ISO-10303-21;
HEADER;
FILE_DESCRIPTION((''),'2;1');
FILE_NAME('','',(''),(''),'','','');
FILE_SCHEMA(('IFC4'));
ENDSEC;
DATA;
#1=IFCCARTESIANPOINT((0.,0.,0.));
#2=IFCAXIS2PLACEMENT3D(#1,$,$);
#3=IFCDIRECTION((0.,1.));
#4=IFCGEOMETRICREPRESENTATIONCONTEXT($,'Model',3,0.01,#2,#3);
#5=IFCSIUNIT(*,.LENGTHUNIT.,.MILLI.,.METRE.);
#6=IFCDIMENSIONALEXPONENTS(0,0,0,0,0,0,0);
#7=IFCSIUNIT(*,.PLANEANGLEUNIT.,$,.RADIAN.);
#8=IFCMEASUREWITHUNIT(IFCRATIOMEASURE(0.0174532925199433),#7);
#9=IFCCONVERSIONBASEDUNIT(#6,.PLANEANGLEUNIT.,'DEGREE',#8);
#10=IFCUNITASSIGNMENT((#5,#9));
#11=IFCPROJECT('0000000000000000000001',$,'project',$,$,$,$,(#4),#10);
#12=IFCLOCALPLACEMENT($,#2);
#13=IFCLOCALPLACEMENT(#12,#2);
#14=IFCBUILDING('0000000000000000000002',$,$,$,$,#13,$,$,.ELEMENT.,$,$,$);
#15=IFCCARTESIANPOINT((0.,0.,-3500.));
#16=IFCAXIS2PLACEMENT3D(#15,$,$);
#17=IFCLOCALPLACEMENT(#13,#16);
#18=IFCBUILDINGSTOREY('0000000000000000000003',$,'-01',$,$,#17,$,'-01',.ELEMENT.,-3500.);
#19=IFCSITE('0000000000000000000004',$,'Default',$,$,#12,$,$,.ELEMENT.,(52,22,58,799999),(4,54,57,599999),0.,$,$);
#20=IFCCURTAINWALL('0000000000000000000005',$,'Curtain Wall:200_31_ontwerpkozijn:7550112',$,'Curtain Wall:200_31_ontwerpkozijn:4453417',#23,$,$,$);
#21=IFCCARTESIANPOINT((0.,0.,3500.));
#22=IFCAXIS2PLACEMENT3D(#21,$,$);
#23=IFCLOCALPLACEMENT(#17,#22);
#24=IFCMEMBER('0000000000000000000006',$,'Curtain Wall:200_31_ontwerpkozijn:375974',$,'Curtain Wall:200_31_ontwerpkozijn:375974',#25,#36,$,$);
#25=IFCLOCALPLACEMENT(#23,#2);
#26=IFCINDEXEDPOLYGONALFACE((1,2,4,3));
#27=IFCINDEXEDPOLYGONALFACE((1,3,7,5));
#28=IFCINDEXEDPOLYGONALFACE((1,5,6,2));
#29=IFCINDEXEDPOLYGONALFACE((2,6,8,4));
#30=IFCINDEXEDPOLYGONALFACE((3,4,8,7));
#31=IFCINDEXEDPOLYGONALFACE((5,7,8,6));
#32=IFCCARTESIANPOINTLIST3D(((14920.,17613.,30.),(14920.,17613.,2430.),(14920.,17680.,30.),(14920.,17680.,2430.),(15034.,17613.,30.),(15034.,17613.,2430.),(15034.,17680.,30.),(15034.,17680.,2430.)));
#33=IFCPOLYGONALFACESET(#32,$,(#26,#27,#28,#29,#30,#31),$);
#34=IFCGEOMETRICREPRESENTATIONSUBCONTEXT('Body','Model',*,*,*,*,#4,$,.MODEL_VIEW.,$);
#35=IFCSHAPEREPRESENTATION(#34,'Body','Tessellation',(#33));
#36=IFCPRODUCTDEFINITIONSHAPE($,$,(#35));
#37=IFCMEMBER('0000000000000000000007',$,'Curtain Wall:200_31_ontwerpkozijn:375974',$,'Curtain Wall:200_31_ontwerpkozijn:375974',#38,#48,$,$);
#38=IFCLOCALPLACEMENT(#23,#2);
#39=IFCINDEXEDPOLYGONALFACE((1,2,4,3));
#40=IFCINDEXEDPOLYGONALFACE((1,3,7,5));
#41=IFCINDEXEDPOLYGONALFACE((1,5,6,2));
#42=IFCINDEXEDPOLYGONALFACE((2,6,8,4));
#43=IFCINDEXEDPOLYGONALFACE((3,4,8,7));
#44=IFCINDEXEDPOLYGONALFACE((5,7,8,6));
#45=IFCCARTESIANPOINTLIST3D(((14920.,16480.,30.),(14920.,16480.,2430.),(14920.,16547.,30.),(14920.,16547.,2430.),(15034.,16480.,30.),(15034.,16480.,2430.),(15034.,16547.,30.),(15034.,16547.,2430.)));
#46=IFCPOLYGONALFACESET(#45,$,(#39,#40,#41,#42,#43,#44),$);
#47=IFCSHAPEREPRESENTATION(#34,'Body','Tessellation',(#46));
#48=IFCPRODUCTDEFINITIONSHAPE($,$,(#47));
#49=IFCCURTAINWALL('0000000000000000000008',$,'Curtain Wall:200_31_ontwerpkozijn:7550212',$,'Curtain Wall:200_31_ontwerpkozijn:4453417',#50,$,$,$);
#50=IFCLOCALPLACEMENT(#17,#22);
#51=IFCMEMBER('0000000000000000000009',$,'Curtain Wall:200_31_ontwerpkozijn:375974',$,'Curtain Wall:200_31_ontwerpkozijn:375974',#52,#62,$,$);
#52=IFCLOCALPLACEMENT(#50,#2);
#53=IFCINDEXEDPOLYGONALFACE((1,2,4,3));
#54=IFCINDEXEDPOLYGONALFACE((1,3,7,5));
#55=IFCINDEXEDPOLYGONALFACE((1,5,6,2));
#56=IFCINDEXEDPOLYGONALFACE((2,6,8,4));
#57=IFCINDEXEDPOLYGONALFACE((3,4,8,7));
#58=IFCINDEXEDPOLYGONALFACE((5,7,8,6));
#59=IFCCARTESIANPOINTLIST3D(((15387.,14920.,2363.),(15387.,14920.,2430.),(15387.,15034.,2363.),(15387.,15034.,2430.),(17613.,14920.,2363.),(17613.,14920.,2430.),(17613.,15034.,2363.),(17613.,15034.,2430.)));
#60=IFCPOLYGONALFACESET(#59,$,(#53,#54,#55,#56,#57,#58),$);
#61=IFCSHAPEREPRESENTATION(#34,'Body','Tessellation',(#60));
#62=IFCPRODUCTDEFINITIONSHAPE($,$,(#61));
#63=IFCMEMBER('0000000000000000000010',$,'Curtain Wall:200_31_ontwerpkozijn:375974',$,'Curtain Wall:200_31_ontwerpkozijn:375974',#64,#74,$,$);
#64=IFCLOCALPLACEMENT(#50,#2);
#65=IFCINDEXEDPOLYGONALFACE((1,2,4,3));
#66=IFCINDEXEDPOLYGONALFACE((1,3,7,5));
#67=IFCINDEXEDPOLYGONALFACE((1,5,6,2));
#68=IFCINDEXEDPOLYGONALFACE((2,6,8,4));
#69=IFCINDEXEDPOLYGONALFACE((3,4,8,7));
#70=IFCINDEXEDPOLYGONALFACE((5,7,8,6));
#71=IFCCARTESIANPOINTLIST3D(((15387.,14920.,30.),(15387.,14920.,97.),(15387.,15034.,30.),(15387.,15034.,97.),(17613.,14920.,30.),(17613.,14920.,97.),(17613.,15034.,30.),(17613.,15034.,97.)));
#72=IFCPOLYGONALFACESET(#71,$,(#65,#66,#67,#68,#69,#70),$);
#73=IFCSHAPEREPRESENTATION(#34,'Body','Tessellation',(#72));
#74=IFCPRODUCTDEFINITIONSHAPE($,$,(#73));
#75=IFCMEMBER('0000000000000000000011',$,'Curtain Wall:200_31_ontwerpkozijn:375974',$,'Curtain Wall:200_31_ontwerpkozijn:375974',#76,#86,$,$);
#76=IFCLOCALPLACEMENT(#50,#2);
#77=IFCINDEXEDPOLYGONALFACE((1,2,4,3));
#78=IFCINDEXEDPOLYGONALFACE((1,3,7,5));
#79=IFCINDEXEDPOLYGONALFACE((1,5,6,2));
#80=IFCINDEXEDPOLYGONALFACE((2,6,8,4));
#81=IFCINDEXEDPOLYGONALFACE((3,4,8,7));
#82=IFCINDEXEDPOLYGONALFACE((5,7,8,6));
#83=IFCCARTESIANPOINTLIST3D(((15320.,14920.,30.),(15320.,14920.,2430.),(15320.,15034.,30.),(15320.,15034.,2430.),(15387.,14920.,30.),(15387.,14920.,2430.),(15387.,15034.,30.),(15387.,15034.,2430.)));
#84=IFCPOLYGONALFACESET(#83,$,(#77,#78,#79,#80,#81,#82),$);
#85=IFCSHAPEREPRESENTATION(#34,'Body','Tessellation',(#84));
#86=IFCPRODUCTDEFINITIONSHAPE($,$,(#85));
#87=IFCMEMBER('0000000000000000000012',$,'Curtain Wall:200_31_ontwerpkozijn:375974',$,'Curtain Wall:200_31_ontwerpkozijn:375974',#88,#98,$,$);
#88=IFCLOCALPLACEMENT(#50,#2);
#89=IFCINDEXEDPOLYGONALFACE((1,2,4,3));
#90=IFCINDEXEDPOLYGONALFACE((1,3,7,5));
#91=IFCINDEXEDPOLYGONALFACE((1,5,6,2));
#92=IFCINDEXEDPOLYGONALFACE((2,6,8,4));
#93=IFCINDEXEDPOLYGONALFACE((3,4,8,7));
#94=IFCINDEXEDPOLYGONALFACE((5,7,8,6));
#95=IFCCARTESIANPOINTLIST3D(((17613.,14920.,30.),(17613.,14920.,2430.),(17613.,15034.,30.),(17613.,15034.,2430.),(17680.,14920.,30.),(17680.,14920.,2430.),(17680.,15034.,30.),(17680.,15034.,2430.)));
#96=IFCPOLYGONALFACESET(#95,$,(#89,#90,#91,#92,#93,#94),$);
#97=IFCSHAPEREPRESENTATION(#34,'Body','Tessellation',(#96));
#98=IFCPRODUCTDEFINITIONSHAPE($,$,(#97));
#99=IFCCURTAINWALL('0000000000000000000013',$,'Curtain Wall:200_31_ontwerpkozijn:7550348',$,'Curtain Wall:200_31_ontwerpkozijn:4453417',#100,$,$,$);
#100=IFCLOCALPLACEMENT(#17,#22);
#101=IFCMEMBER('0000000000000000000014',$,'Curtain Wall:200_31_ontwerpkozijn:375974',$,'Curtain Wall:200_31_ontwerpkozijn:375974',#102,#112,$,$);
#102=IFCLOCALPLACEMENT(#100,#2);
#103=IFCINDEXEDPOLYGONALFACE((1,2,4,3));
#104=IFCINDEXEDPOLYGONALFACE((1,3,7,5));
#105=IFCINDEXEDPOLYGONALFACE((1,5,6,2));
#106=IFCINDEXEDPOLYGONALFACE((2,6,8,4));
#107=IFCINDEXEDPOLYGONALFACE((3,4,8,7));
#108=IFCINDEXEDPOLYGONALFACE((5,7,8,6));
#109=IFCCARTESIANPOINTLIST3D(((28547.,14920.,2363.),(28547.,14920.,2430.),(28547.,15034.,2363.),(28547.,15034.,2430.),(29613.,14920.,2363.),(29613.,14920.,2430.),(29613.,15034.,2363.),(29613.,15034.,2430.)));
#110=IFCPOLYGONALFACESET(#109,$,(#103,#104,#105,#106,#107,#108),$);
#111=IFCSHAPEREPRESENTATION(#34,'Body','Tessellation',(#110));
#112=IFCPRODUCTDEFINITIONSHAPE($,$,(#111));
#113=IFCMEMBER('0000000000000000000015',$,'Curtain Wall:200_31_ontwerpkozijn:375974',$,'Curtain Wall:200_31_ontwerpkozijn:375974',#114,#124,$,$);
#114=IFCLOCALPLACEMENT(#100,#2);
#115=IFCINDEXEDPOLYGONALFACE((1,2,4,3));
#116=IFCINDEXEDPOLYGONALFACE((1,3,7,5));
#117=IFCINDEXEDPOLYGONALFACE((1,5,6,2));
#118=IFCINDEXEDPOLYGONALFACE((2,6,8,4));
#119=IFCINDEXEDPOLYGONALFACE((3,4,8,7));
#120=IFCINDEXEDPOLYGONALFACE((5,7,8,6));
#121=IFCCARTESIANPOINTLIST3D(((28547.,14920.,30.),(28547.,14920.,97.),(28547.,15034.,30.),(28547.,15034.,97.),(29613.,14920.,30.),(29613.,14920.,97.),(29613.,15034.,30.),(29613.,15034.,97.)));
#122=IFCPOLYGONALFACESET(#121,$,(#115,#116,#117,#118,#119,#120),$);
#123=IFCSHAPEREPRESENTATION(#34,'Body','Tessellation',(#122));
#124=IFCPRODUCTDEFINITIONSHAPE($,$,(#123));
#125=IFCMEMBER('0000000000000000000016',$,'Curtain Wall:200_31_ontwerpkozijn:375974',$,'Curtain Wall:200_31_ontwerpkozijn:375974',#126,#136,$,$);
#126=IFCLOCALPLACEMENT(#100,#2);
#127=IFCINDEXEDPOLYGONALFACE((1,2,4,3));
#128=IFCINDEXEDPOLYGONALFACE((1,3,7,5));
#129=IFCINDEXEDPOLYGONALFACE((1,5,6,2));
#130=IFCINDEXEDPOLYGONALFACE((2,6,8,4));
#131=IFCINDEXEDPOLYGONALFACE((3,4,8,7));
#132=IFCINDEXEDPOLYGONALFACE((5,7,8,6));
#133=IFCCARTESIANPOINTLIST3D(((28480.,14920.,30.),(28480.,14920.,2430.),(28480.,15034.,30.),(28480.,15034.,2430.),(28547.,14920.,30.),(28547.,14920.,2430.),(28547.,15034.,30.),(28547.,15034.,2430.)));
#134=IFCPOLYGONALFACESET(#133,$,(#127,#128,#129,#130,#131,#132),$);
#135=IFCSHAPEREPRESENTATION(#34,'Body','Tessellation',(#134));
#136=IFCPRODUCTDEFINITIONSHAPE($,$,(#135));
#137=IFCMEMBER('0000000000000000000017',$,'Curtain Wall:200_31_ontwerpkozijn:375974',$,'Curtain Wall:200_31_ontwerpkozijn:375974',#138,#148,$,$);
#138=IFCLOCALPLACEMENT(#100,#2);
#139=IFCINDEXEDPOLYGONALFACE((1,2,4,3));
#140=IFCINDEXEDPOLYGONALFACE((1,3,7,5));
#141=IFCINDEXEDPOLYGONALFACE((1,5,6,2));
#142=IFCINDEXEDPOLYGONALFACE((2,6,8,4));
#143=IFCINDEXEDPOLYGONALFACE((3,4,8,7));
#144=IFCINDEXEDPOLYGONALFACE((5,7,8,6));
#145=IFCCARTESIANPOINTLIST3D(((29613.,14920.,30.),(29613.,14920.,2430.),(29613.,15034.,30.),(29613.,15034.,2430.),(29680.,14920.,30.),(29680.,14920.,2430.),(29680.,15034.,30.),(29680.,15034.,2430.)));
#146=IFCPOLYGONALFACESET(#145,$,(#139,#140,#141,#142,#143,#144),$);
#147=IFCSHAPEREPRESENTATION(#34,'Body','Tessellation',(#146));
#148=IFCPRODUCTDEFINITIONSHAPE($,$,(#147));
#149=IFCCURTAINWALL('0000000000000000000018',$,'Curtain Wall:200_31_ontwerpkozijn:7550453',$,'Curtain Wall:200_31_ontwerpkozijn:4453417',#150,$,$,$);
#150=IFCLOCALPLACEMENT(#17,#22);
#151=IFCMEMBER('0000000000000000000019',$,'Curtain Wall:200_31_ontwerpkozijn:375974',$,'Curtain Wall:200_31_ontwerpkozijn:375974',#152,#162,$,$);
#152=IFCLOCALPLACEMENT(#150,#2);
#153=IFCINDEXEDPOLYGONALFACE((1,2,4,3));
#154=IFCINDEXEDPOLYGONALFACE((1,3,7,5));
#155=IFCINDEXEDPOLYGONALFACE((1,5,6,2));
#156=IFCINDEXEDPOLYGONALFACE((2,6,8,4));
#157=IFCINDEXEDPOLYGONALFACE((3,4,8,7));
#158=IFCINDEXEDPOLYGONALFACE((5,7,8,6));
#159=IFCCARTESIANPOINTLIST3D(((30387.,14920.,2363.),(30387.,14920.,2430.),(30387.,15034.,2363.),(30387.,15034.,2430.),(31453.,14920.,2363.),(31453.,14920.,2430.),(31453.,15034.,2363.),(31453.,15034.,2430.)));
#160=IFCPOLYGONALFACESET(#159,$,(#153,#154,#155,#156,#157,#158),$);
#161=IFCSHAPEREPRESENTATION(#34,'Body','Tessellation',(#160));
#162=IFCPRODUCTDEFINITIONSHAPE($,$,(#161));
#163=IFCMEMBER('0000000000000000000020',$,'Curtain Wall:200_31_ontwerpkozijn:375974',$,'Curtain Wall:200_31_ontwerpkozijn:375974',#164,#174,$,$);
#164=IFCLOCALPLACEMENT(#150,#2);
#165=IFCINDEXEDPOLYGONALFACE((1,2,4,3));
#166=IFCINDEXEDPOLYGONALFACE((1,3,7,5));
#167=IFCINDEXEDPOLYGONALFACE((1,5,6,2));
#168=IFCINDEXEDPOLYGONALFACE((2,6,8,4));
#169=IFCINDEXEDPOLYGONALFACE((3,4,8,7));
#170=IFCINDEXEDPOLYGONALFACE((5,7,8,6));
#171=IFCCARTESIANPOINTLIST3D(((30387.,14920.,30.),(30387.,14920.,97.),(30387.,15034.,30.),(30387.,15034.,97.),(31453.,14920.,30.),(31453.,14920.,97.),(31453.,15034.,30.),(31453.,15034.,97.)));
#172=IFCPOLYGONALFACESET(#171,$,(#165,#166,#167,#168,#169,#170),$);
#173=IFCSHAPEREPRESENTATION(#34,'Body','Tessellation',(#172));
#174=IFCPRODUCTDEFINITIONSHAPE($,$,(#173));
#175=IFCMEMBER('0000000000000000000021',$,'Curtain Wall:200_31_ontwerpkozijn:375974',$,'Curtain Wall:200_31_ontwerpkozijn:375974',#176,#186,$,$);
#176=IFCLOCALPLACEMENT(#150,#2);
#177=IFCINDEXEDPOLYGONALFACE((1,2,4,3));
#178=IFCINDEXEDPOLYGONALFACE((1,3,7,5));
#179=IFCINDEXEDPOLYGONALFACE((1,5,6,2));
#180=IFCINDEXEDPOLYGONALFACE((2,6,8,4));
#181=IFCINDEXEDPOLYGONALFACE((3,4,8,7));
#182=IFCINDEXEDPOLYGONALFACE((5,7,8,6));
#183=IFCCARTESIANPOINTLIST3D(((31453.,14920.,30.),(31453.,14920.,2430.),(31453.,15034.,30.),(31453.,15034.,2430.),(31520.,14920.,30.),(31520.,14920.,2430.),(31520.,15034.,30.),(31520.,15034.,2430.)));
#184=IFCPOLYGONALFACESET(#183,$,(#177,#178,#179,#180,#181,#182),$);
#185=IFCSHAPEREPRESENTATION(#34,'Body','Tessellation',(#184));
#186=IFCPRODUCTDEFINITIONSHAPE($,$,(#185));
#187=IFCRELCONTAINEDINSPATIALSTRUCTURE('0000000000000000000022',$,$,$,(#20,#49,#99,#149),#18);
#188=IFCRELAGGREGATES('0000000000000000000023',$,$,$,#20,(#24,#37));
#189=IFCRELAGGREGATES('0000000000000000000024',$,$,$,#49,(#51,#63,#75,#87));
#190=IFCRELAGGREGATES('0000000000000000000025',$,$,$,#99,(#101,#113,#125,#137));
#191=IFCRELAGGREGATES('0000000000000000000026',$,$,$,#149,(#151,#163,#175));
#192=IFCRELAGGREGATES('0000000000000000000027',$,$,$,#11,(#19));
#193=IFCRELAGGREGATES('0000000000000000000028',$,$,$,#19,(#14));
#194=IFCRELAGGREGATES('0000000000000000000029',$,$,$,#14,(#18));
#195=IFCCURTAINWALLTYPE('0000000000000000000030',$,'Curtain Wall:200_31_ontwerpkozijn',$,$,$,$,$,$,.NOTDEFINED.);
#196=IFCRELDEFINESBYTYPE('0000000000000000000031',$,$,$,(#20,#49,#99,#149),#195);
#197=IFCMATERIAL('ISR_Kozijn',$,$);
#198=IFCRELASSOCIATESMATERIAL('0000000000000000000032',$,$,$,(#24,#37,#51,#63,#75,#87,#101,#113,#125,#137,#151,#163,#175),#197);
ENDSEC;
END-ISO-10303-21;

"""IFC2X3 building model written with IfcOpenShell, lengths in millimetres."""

from ifc_helpers import new_model, entity, si_unit, converted_unit, direction, frame, frame_2d, origin, origin_2d_with_axis, place, context, subcontext, project, spatial, rectangle, extrude, material, type_object, element, aggregate, save


model = new_model("IFC2X3")

# Units and contexts
model_context = context("Model", 3, precision=0.01, world=origin(), true_north=direction((0.0, 1.0)))
body_context = subcontext(model_context, "Body", "Model", "MODEL_VIEW")
ifc_project = project(units=[si_unit("LENGTHUNIT", "METRE", prefix="MILLI"), converted_unit("PLANEANGLEUNIT", "DEGREE", entity("IfcRatioMeasure", 0.0174532925199433), si_unit("PLANEANGLEUNIT", "RADIAN"), dimensions=[0, 0, 0, 0, 0, 0, 0])], contexts=[model_context])

# Site, building, storey
site_placement = place(None, origin())
site = spatial("IfcSite", under=ifc_project, at=site_placement, Name="Default", CompositionType="ELEMENT", RefLatitude=(52, 22, 58, 799999), RefLongitude=(4, 54, 57, 599999), RefElevation=0.0)
building_placement = place(site_placement, origin())
building = spatial("IfcBuilding", under=site, at=building_placement, CompositionType="ELEMENT")
storey_placement = place(building_placement, frame((0.0, 0.0, -3500.0)))
storey = spatial("IfcBuildingStorey", under=building, at=storey_placement, Name="-01", LongName="-01", CompositionType="ELEMENT", Elevation=-3500.0)

# Curtain walls, members
curtain_wall_type = type_object("IfcCurtainWallType", Name="Curtain Wall:200_31_ontwerpkozijn", PredefinedType="NOTDEFINED")
curtain_wall_1_placement = place(storey_placement, frame((0.0, 0.0, 3500.0)))
curtain_wall_1 = element("IfcCurtainWall", 1, at=curtain_wall_1_placement, inside=storey, type_object=curtain_wall_type, Name="Curtain Wall:200_31_ontwerpkozijn:7550112", ObjectType="Curtain Wall:200_31_ontwerpkozijn:4453417")
ifc_material_1 = material(Name="ISR_Kozijn")
member_1_placement = place(curtain_wall_1_placement, origin())
member_1 = element("IfcMember", 2, at=member_1_placement, material=ifc_material_1, Name="Curtain Wall:200_31_ontwerpkozijn:375974", ObjectType="Curtain Wall:200_31_ontwerpkozijn:375974", context=body_context, shape_type="SweptSolid", body=[
    extrude(rectangle(XDim=114.0, YDim=67.0, at=frame_2d((0.0, 0.0), x_axis=(1.0, 0.0))), frame((14977.0, 17646.5, 30.0), z_axis=(0.0, 0.0, 1.0), x_axis=(-1.0, 0.0, 0.0)), (0.0, 0.0, 1.0), 2400.0),
])
member_2_placement = place(curtain_wall_1_placement, origin())
member_2 = element("IfcMember", 3, at=member_2_placement, material=ifc_material_1, Name="Curtain Wall:200_31_ontwerpkozijn:375974", ObjectType="Curtain Wall:200_31_ontwerpkozijn:375974", context=body_context, shape_type="SweptSolid", body=[
    extrude(rectangle(XDim=114.0, YDim=67.0, at=frame_2d((0.0, 0.0), x_axis=(1.0, 0.0))), frame((14977.0, 16513.5, 2430.0), z_axis=(0.0, 0.0, -1.0), x_axis=(-1.0, 0.0, 0.0)), (0.0, 0.0, 1.0), 2400.0),
])
aggregate(curtain_wall_1, [member_1, member_2])
curtain_wall_2_placement = place(storey_placement, frame((0.0, 0.0, 3500.0)))
curtain_wall_2 = element("IfcCurtainWall", 4, at=curtain_wall_2_placement, inside=storey, type_object=curtain_wall_type, Name="Curtain Wall:200_31_ontwerpkozijn:7550212", ObjectType="Curtain Wall:200_31_ontwerpkozijn:4453417")
member_3_placement = place(curtain_wall_2_placement, origin())
member_3 = element("IfcMember", 5, at=member_3_placement, material=ifc_material_1, Name="Curtain Wall:200_31_ontwerpkozijn:375974", ObjectType="Curtain Wall:200_31_ontwerpkozijn:375974", context=body_context, shape_type="SweptSolid", body=[
    extrude(rectangle(XDim=67.0, YDim=114.0, at=frame_2d((0.0, 0.0), x_axis=(1.0, 0.0))), frame((15387.0, 14977.0, 2396.5), z_axis=(1.0, 0.0, 0.0), x_axis=(0.0, 0.0, -1.0)), (0.0, 0.0, 1.0), 2226.0),
])
member_4_placement = place(curtain_wall_2_placement, origin())
member_4 = element("IfcMember", 6, at=member_4_placement, material=ifc_material_1, Name="Curtain Wall:200_31_ontwerpkozijn:375974", ObjectType="Curtain Wall:200_31_ontwerpkozijn:375974", context=body_context, shape_type="SweptSolid", body=[
    extrude(rectangle(XDim=67.0, YDim=114.0, at=frame_2d((0.0, 0.0), x_axis=(1.0, 0.0))), frame((17613.0, 14977.0, 63.5), z_axis=(-1.0, 0.0, 0.0), x_axis=(0.0, 0.0, -1.0)), (0.0, 0.0, 1.0), 2226.0),
])
member_5_placement = place(curtain_wall_2_placement, origin())
member_5 = element("IfcMember", 7, at=member_5_placement, material=ifc_material_1, Name="Curtain Wall:200_31_ontwerpkozijn:375974", ObjectType="Curtain Wall:200_31_ontwerpkozijn:375974", context=body_context, shape_type="SweptSolid", body=[
    extrude(rectangle(XDim=67.0, YDim=114.0, at=frame_2d((0.0, 0.0), x_axis=(1.0, 0.0))), frame((15353.5, 14977.0, 30.0), z_axis=(0.0, 0.0, 1.0), x_axis=(-1.0, 0.0, 0.0)), (0.0, 0.0, 1.0), 2400.0),
])
member_6_placement = place(curtain_wall_2_placement, origin())
member_6 = element("IfcMember", 8, at=member_6_placement, material=ifc_material_1, Name="Curtain Wall:200_31_ontwerpkozijn:375974", ObjectType="Curtain Wall:200_31_ontwerpkozijn:375974", context=body_context, shape_type="SweptSolid", body=[
    extrude(rectangle(XDim=67.0, YDim=114.0, at=frame_2d((0.0, 0.0), x_axis=(1.0, 0.0))), frame((17646.5, 14977.0, 2430.0), z_axis=(0.0, 0.0, -1.0), x_axis=(-1.0, 0.0, 0.0)), (0.0, 0.0, 1.0), 2400.0),
])
aggregate(curtain_wall_2, [member_3, member_4, member_5, member_6])
curtain_wall_3_placement = place(storey_placement, frame((0.0, 0.0, 3500.0)))
curtain_wall_3 = element("IfcCurtainWall", 9, at=curtain_wall_3_placement, inside=storey, type_object=curtain_wall_type, Name="Curtain Wall:200_31_ontwerpkozijn:7550348", ObjectType="Curtain Wall:200_31_ontwerpkozijn:4453417")
member_7_placement = place(curtain_wall_3_placement, origin())
member_7 = element("IfcMember", 10, at=member_7_placement, material=ifc_material_1, Name="Curtain Wall:200_31_ontwerpkozijn:375974", ObjectType="Curtain Wall:200_31_ontwerpkozijn:375974", context=body_context, shape_type="SweptSolid", body=[
    extrude(rectangle(XDim=67.0, YDim=114.0, at=frame_2d((0.0, 0.0), x_axis=(1.0, 0.0))), frame((28547.0, 14977.0, 2396.5), z_axis=(1.0, 0.0, 0.0), x_axis=(0.0, 0.0, -1.0)), (0.0, 0.0, 1.0), 1066.0),
])
member_8_placement = place(curtain_wall_3_placement, origin())
member_8 = element("IfcMember", 11, at=member_8_placement, material=ifc_material_1, Name="Curtain Wall:200_31_ontwerpkozijn:375974", ObjectType="Curtain Wall:200_31_ontwerpkozijn:375974", context=body_context, shape_type="SweptSolid", body=[
    extrude(rectangle(XDim=67.0, YDim=114.0, at=frame_2d((0.0, 0.0), x_axis=(1.0, 0.0))), frame((29613.0, 14977.0, 63.5), z_axis=(-1.0, 0.0, 0.0), x_axis=(0.0, 0.0, -1.0)), (0.0, 0.0, 1.0), 1066.0),
])
member_9_placement = place(curtain_wall_3_placement, origin())
member_9 = element("IfcMember", 12, at=member_9_placement, material=ifc_material_1, Name="Curtain Wall:200_31_ontwerpkozijn:375974", ObjectType="Curtain Wall:200_31_ontwerpkozijn:375974", context=body_context, shape_type="SweptSolid", body=[
    extrude(rectangle(XDim=67.0, YDim=114.0, at=origin_2d_with_axis()), frame((28513.5, 14977.0, 30.0), z_axis=(0.0, 0.0, 1.0), x_axis=(-1.0, 0.0, 0.0)), (0.0, 0.0, 1.0), 2400.0),
])
member_10_placement = place(curtain_wall_3_placement, origin())
member_10 = element("IfcMember", 13, at=member_10_placement, material=ifc_material_1, Name="Curtain Wall:200_31_ontwerpkozijn:375974", ObjectType="Curtain Wall:200_31_ontwerpkozijn:375974", context=body_context, shape_type="SweptSolid", body=[
    extrude(rectangle(XDim=67.0, YDim=114.0, at=origin_2d_with_axis()), frame((29646.5, 14977.0, 2430.0), z_axis=(0.0, 0.0, -1.0), x_axis=(-1.0, 0.0, 0.0)), (0.0, 0.0, 1.0), 2400.0),
])
aggregate(curtain_wall_3, [member_7, member_8, member_9, member_10])
curtain_wall_4_placement = place(storey_placement, frame((0.0, 0.0, 3500.0)))
curtain_wall_4 = element("IfcCurtainWall", 14, at=curtain_wall_4_placement, inside=storey, type_object=curtain_wall_type, Name="Curtain Wall:200_31_ontwerpkozijn:7550453", ObjectType="Curtain Wall:200_31_ontwerpkozijn:4453417")
member_11_placement = place(curtain_wall_4_placement, origin())
member_11 = element("IfcMember", 15, at=member_11_placement, material=ifc_material_1, Name="Curtain Wall:200_31_ontwerpkozijn:375974", ObjectType="Curtain Wall:200_31_ontwerpkozijn:375974", context=body_context, shape_type="SweptSolid", body=[
    extrude(rectangle(XDim=67.0, YDim=114.0, at=frame_2d((0.0, 0.0), x_axis=(1.0, 0.0))), frame((31453.0, 14977.0, 2396.5), z_axis=(-1.0, 0.0, 0.0), x_axis=(0.0, 0.0, -1.0)), (0.0, 0.0, 1.0), 1066.0),
])
member_12_placement = place(curtain_wall_4_placement, origin())
member_12 = element("IfcMember", 16, at=member_12_placement, material=ifc_material_1, Name="Curtain Wall:200_31_ontwerpkozijn:375974", ObjectType="Curtain Wall:200_31_ontwerpkozijn:375974", context=body_context, shape_type="SweptSolid", body=[
    extrude(rectangle(XDim=67.0, YDim=114.0, at=frame_2d((0.0, 0.0), x_axis=(1.0, 0.0))), frame((30387.0, 14977.0, 63.5), z_axis=(1.0, 0.0, 0.0), x_axis=(0.0, 0.0, -1.0)), (0.0, 0.0, 1.0), 1066.0),
])
member_13_placement = place(curtain_wall_4_placement, origin())
member_13 = element("IfcMember", 17, at=member_13_placement, material=ifc_material_1, Name="Curtain Wall:200_31_ontwerpkozijn:375974", ObjectType="Curtain Wall:200_31_ontwerpkozijn:375974", context=body_context, shape_type="SweptSolid", body=[
    extrude(rectangle(XDim=67.0, YDim=114.0, at=origin_2d_with_axis()), frame((31486.5, 14977.0, 30.0), z_axis=(0.0, 0.0, 1.0), x_axis=(-1.0, 0.0, 0.0)), (0.0, 0.0, 1.0), 2400.0),
])
aggregate(curtain_wall_4, [member_11, member_12, member_13])

save(model, "model.ifc")
